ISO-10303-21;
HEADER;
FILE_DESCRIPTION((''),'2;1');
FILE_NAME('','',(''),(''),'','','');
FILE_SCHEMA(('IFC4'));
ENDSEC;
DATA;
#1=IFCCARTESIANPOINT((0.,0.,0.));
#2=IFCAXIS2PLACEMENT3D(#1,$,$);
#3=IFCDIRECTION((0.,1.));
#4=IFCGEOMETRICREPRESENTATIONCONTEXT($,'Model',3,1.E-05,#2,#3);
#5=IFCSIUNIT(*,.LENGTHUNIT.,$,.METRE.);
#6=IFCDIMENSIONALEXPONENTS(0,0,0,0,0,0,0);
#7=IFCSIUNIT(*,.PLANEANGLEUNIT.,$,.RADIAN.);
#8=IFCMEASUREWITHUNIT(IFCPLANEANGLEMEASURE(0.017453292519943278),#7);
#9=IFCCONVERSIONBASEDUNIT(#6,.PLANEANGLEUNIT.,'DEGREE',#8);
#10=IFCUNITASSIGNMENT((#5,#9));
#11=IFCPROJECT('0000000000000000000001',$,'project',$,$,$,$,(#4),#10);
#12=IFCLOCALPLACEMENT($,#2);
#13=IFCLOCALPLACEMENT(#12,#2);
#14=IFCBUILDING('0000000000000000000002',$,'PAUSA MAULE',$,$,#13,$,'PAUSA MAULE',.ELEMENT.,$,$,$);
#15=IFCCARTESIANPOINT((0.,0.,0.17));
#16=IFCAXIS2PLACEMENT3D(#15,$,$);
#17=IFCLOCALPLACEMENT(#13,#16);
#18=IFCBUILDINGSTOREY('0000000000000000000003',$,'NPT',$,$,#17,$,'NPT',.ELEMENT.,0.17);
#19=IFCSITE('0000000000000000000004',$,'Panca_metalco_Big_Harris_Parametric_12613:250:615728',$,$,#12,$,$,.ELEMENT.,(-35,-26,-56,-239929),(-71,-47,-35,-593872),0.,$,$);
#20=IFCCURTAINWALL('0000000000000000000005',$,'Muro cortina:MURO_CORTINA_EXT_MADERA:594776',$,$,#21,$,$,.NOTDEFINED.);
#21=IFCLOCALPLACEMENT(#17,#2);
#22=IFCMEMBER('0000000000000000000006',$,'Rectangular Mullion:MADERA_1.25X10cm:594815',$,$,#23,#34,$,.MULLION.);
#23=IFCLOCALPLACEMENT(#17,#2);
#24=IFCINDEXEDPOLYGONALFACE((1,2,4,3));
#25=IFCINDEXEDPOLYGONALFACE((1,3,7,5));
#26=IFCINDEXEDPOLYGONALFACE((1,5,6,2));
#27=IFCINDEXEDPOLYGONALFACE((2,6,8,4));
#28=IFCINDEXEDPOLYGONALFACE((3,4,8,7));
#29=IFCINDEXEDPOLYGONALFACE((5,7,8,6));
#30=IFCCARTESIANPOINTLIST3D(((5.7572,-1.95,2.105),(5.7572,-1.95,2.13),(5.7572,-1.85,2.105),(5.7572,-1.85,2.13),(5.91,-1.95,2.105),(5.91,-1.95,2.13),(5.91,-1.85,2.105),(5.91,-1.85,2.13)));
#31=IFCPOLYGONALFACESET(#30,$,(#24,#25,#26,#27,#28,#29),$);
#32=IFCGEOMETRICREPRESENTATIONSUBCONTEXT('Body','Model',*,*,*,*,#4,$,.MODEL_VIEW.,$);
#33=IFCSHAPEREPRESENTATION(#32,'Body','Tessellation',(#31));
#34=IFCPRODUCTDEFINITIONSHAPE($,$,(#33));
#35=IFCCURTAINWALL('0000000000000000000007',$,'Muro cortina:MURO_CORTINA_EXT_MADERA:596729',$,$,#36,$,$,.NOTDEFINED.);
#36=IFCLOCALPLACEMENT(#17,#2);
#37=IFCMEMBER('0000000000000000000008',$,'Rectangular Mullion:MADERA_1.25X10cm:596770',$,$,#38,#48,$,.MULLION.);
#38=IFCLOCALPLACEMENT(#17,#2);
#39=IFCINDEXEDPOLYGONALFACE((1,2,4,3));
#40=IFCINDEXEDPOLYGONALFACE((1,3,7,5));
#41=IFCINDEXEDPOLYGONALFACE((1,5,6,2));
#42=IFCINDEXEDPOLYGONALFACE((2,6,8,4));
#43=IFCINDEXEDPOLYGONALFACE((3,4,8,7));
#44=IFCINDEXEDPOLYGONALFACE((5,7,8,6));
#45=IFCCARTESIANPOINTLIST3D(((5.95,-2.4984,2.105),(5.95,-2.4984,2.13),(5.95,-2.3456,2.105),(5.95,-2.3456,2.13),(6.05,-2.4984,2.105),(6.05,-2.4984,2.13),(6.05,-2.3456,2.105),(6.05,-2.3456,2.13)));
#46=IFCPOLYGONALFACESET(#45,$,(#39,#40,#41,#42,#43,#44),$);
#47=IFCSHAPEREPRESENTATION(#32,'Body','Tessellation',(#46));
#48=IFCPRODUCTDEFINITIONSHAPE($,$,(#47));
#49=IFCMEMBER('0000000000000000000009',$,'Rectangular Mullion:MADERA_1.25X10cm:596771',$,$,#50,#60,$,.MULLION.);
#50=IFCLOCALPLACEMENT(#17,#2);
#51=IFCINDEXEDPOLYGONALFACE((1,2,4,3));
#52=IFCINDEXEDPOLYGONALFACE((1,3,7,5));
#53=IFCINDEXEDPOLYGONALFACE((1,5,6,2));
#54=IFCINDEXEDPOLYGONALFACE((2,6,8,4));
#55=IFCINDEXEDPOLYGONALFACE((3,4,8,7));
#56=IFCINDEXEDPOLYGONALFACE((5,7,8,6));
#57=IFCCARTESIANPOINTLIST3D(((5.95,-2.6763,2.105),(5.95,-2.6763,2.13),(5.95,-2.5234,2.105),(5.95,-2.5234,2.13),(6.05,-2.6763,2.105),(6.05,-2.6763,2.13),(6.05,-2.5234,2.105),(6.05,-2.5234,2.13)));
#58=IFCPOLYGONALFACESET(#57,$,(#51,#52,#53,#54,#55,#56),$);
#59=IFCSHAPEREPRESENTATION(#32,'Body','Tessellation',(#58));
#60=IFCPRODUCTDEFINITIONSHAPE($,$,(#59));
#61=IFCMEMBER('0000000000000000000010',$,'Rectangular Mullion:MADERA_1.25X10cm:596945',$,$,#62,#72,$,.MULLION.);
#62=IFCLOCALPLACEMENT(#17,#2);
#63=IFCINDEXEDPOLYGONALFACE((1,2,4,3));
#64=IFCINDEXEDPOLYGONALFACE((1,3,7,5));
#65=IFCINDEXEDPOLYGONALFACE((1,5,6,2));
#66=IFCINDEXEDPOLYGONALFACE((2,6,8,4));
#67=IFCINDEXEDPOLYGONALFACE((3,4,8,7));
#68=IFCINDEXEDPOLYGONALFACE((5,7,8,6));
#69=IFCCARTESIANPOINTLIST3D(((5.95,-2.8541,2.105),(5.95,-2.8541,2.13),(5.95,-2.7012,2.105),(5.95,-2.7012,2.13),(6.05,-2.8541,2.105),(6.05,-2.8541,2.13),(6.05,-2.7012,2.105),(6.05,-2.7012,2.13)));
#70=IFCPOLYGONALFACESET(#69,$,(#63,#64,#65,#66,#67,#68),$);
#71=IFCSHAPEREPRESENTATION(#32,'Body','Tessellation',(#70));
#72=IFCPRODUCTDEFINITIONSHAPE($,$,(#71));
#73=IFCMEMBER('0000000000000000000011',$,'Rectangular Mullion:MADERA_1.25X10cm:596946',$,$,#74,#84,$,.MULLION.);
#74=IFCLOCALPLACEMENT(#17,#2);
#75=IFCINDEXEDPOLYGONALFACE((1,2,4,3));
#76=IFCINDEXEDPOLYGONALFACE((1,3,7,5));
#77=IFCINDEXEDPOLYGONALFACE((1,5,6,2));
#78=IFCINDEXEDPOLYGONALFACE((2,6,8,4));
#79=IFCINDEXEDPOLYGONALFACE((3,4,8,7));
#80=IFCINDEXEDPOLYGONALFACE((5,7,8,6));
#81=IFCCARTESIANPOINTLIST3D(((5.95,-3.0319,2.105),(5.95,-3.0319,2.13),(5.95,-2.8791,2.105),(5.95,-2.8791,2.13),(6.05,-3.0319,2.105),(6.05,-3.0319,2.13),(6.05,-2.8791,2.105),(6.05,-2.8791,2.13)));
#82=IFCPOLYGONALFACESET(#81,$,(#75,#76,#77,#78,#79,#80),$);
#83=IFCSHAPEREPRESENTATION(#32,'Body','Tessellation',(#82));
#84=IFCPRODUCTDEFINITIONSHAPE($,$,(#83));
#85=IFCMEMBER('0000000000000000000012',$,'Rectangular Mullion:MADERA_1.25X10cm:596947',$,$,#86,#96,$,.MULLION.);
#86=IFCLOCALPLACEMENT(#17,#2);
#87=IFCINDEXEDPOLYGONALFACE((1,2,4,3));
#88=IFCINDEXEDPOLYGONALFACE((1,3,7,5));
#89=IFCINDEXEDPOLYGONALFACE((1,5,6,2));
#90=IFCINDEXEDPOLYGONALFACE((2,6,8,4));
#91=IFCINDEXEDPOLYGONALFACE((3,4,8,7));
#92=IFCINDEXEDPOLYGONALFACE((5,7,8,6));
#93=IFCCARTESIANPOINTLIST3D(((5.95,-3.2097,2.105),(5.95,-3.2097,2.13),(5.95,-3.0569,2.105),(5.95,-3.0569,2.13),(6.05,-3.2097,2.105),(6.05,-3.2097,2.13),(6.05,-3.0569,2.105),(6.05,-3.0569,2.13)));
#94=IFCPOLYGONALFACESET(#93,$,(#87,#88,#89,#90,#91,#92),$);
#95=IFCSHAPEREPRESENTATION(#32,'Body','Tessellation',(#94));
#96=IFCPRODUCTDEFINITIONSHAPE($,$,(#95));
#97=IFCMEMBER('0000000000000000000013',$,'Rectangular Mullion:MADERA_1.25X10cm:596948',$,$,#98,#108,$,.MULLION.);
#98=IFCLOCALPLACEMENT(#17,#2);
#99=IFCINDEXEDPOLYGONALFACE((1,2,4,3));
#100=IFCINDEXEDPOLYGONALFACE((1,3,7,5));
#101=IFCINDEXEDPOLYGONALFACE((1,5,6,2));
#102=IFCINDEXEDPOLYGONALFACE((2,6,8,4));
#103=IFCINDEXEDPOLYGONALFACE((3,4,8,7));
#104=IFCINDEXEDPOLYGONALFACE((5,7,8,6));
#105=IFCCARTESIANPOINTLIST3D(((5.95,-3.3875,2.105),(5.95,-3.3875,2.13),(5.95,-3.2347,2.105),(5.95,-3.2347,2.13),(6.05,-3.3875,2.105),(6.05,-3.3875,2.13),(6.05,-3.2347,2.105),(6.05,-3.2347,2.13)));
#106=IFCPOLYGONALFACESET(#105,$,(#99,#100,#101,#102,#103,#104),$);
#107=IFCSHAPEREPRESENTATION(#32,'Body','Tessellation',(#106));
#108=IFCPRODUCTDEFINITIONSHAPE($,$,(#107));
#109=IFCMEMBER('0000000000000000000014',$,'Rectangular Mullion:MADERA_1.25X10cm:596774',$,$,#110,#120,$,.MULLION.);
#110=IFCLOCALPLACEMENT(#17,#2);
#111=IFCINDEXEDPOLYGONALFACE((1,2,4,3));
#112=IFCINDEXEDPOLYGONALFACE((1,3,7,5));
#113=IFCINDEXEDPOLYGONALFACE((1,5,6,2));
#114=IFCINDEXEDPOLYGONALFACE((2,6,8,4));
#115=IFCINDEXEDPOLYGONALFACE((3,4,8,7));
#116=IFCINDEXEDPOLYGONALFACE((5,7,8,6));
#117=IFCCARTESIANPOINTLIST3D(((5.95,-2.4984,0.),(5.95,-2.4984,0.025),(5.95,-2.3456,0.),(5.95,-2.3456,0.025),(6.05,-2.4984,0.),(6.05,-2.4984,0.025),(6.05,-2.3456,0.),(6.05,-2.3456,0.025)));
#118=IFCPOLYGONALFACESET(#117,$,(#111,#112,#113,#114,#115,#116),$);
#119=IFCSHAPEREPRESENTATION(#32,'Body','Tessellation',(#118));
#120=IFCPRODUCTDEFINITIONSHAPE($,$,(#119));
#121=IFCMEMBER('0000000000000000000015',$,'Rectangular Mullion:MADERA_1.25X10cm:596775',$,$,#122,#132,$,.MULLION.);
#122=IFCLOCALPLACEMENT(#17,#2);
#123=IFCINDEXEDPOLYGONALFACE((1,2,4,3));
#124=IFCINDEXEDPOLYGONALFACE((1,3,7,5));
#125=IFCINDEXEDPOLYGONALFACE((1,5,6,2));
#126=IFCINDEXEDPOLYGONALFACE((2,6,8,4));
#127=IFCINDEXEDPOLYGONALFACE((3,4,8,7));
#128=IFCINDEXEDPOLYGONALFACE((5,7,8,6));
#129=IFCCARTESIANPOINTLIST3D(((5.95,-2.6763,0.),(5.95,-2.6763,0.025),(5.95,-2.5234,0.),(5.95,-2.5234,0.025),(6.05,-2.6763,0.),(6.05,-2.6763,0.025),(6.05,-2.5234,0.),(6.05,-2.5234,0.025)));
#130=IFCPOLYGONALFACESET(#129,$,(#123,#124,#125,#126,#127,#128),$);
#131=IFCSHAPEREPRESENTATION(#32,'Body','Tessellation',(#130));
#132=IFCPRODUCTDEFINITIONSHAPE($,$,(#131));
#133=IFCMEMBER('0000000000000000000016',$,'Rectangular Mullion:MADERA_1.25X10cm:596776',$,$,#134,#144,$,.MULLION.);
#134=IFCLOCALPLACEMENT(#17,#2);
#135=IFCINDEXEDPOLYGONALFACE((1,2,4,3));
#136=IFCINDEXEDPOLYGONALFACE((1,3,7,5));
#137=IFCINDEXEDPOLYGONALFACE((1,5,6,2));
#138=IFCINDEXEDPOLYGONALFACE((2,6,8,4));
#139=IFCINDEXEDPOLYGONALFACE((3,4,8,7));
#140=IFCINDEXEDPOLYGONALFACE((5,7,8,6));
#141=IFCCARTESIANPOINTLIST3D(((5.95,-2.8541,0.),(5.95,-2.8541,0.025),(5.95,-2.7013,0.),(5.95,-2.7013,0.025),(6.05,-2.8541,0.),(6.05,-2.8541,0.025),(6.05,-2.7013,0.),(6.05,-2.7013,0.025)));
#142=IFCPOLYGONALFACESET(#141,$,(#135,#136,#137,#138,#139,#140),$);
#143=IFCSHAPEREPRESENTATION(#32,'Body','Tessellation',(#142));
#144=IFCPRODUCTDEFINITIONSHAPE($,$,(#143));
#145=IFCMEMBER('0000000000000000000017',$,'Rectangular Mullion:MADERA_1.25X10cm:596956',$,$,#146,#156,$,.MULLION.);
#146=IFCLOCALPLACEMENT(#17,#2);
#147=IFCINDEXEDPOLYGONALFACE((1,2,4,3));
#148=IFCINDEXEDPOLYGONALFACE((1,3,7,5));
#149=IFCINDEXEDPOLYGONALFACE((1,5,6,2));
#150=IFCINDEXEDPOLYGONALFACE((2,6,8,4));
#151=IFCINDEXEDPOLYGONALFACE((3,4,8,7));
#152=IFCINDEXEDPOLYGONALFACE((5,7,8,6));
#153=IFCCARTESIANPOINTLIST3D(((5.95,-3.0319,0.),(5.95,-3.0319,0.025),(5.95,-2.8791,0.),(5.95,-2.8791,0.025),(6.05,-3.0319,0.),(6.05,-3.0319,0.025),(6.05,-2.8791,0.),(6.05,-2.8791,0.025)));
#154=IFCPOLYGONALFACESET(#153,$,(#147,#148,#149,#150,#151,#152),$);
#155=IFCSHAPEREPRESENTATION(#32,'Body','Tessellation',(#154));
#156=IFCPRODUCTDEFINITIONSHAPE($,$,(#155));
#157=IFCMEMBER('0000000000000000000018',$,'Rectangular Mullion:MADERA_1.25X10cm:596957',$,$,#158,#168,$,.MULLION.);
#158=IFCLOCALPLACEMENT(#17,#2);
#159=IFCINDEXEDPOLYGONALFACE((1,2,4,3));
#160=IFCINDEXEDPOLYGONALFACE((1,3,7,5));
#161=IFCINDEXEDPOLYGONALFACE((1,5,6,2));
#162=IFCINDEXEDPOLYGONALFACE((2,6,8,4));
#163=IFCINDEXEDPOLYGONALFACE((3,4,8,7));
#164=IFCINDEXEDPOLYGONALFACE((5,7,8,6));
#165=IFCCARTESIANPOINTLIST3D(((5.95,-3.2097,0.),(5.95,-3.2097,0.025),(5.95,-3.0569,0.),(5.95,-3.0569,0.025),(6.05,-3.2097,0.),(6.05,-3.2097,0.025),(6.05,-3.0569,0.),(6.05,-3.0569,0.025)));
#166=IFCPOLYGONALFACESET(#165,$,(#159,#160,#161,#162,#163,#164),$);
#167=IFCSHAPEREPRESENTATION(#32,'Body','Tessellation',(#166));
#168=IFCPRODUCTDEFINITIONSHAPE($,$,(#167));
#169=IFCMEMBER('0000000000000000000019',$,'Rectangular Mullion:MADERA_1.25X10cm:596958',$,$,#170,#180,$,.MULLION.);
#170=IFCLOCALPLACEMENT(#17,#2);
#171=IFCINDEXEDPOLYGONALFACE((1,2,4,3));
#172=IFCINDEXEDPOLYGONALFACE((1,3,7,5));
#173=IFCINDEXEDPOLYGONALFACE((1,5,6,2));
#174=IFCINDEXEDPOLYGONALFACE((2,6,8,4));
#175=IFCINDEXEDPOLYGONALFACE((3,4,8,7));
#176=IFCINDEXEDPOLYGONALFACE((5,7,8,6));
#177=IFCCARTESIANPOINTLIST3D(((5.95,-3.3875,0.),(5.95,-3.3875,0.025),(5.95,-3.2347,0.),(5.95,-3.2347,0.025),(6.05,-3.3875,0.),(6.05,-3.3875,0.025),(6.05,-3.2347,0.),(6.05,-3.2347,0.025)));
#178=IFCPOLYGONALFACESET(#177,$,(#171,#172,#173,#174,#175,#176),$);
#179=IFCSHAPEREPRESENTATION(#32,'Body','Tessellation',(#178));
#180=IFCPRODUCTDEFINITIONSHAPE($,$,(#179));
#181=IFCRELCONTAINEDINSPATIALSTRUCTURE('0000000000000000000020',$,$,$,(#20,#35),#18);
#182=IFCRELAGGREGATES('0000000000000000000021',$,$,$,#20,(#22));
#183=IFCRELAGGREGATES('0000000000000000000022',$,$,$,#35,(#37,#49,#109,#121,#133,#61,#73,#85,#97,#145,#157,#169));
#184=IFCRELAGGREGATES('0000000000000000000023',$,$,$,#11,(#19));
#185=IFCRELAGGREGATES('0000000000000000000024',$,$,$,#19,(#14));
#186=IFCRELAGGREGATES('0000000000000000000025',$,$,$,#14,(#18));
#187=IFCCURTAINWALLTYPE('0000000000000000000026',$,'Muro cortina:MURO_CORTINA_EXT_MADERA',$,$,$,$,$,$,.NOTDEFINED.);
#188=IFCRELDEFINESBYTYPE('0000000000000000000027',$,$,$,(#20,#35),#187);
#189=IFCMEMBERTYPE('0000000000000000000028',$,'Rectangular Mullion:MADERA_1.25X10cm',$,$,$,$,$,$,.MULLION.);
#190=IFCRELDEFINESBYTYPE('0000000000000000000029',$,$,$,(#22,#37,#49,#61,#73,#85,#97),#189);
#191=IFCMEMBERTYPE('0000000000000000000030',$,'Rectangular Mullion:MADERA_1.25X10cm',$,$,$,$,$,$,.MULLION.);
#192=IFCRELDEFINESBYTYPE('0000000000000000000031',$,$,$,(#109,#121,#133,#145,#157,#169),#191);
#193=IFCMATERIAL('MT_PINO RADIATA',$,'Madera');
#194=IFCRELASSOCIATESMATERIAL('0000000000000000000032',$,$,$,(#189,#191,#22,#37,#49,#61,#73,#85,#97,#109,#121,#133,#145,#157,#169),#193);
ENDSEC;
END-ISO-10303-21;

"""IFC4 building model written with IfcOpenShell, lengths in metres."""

from ifc_helpers import new_model, entity, si_unit, converted_unit, direction, frame, frame_2d, origin, place, context, subcontext, project, spatial, rectangle, extrude, source, transform, mapped, material, material_profile, profile_set, profile_usage, type_object, type_shapes, element, aggregate, save


model = new_model("IFC4")

# Units and contexts
model_context = context("Model", 3, precision=1e-05, world=origin(), true_north=direction((0.0, 1.0)))
body_context = subcontext(model_context, "Body", "Model", "MODEL_VIEW")
ifc_project = project(units=[si_unit("LENGTHUNIT", "METRE"), converted_unit("PLANEANGLEUNIT", "DEGREE", entity("IfcPlaneAngleMeasure", 0.017453292519943278), si_unit("PLANEANGLEUNIT", "RADIAN"), dimensions=[0, 0, 0, 0, 0, 0, 0])], contexts=[model_context])

# Site, building, storey
site_placement = place(None, origin())
site = spatial("IfcSite", under=ifc_project, at=site_placement, Name="Panca_metalco_Big_Harris_Parametric_12613:250:615728", CompositionType="ELEMENT", RefLatitude=(-35, -26, -56, -239929), RefLongitude=(-71, -47, -35, -593872), RefElevation=0.0)
building_placement = place(site_placement, origin())
building = spatial("IfcBuilding", under=site, at=building_placement, Name="PAUSA MAULE", LongName="PAUSA MAULE", CompositionType="ELEMENT")
storey_placement = place(building_placement, frame((0.0, 0.0, 0.17)))
storey = spatial("IfcBuildingStorey", under=building, at=storey_placement, Name="NPT", LongName="NPT", CompositionType="ELEMENT", Elevation=0.17)

# Curtain wall, member
curtain_wall_type = type_object("IfcCurtainWallType", Name="Muro cortina:MURO_CORTINA_EXT_MADERA", PredefinedType="NOTDEFINED")
curtain_wall_1_placement = place(storey_placement, frame((0.0, 0.0, -0.17)))
curtain_wall_1 = element("IfcCurtainWall", 1, at=curtain_wall_1_placement, inside=storey, type_object=curtain_wall_type, Name="Muro cortina:MURO_CORTINA_EXT_MADERA:594776", PredefinedType="NOTDEFINED")
ifc_material = material(Name="MT_PINO RADIATA", Category="Madera")
ifc_material_profile = material_profile(ifc_material, rectangle(XDim=0.025, YDim=0.1, at=frame_2d((0.0, 0.0), x_axis=(1.0, 0.0))), Name="MADERA_1.25X10cm")
ifc_profile_set = profile_set([ifc_material_profile], Name="MADERA_1.25X10cm")
ifc_profile_usage = profile_usage(ifc_profile_set)
member_type_1 = type_object("IfcMemberType", Name="Rectangular Mullion:MADERA_1.25X10cm", PredefinedType="MULLION", material=ifc_profile_set)
shared_shape_1 = source(origin(), body_context, "Body", "SweptSolid", [
    extrude(rectangle(XDim=0.025, YDim=0.1, at=frame_2d((0.0, 0.0), x_axis=(1.0, 0.0))), frame((-0.0125, 0.0, -0.1528), z_axis=(0.0, 0.0, 1.0), x_axis=(-1.0, 0.0, 0.0)), (0.0, 0.0, 1.0), 0.1528),
])
type_shapes(member_type_1, [shared_shape_1])
member_1_placement = place(curtain_wall_1_placement, frame((5.91, -1.9, 2.3), z_axis=(1.0, 0.0, 0.0), x_axis=(0.0, 0.0, 1.0)))
member_1 = element("IfcMember", 2, at=member_1_placement, type_object=member_type_1, material=ifc_profile_usage, Name="Rectangular Mullion:MADERA_1.25X10cm:594815", PredefinedType="MULLION", context=body_context, shape_type="MappedRepresentation", body=[
    mapped(shared_shape_1, transform((0.0, 0.0, 0.0), scale=1.0)),
])

# Curtain wall, members
curtain_wall_2_placement = place(storey_placement, frame((0.0, 0.0, -0.17)))
curtain_wall_2 = element("IfcCurtainWall", 3, at=curtain_wall_2_placement, inside=storey, type_object=curtain_wall_type, Name="Muro cortina:MURO_CORTINA_EXT_MADERA:596729", PredefinedType="NOTDEFINED")
member_2_placement = place(curtain_wall_2_placement, frame((6.0, -2.4984, 2.3), z_axis=(0.0, -1.0, 0.0), x_axis=(0.0, 0.0, 1.0)))
member_2 = element("IfcMember", 4, at=member_2_placement, type_object=member_type_1, material=ifc_profile_usage, Name="Rectangular Mullion:MADERA_1.25X10cm:596770", PredefinedType="MULLION", context=body_context, shape_type="MappedRepresentation", body=[
    mapped(shared_shape_1, transform((0.0, 0.0, 0.0), scale=1.0)),
])
member_3_placement = place(curtain_wall_2_placement, frame((6.0, -2.6763, 2.3), z_axis=(0.0, -1.0, 0.0), x_axis=(0.0, 0.0, 1.0)))
member_3 = element("IfcMember", 5, at=member_3_placement, type_object=member_type_1, material=ifc_profile_usage, Name="Rectangular Mullion:MADERA_1.25X10cm:596771", PredefinedType="MULLION", context=body_context, shape_type="MappedRepresentation", body=[
    mapped(shared_shape_1, transform((0.0, 0.0, 0.0), scale=1.0)),
])
member_4_placement = place(curtain_wall_2_placement, frame((6.0, -2.8541, 2.3), z_axis=(0.0, -1.0, 0.0), x_axis=(0.0, 0.0, 1.0)))
member_4 = element("IfcMember", 6, at=member_4_placement, type_object=member_type_1, material=ifc_profile_usage, Name="Rectangular Mullion:MADERA_1.25X10cm:596945", PredefinedType="MULLION", context=body_context, shape_type="MappedRepresentation", body=[
    mapped(shared_shape_1, transform((0.0, 0.0, 0.0), scale=1.0)),
])
member_5_placement = place(curtain_wall_2_placement, frame((6.0, -3.0319, 2.3), z_axis=(0.0, -1.0, 0.0), x_axis=(0.0, 0.0, 1.0)))
member_5 = element("IfcMember", 7, at=member_5_placement, type_object=member_type_1, material=ifc_profile_usage, Name="Rectangular Mullion:MADERA_1.25X10cm:596946", PredefinedType="MULLION", context=body_context, shape_type="MappedRepresentation", body=[
    mapped(shared_shape_1, transform((0.0, 0.0, 0.0), scale=1.0)),
])
member_6_placement = place(curtain_wall_2_placement, frame((6.0, -3.2097, 2.3), z_axis=(0.0, -1.0, 0.0), x_axis=(0.0, 0.0, 1.0)))
member_6 = element("IfcMember", 8, at=member_6_placement, type_object=member_type_1, material=ifc_profile_usage, Name="Rectangular Mullion:MADERA_1.25X10cm:596947", PredefinedType="MULLION", context=body_context, shape_type="MappedRepresentation", body=[
    mapped(shared_shape_1, transform((0.0, 0.0, 0.0), scale=1.0)),
])
member_7_placement = place(curtain_wall_2_placement, frame((6.0, -3.3875, 2.3), z_axis=(0.0, -1.0, 0.0), x_axis=(0.0, 0.0, 1.0)))
member_7 = element("IfcMember", 9, at=member_7_placement, type_object=member_type_1, material=ifc_profile_usage, Name="Rectangular Mullion:MADERA_1.25X10cm:596948", PredefinedType="MULLION", context=body_context, shape_type="MappedRepresentation", body=[
    mapped(shared_shape_1, transform((0.0, 0.0, 0.0), scale=1.0)),
])
member_type_2 = type_object("IfcMemberType", Name="Rectangular Mullion:MADERA_1.25X10cm", PredefinedType="MULLION", material=ifc_profile_set)
shared_shape_2 = source(origin(), body_context, "Body", "SweptSolid", [
    extrude(rectangle(XDim=0.025, YDim=0.1, at=frame_2d((0.0, 0.0), x_axis=(1.0, 0.0))), frame((-0.0125, 0.0, -0.1528), z_axis=(0.0, 0.0, 1.0), x_axis=(-1.0, 0.0, 0.0)), (0.0, 0.0, 1.0), 0.1528),
])
type_shapes(member_type_2, [shared_shape_2])
member_8_placement = place(curtain_wall_2_placement, frame((6.0, -2.3456, 0.17), z_axis=(0.0, 1.0, 0.0), x_axis=(0.0, 0.0, -1.0)))
member_8 = element("IfcMember", 10, at=member_8_placement, type_object=member_type_2, material=ifc_profile_usage, Name="Rectangular Mullion:MADERA_1.25X10cm:596774", PredefinedType="MULLION", context=body_context, shape_type="MappedRepresentation", body=[
    mapped(shared_shape_2, transform((0.0, 0.0, 0.0), scale=1.0)),
])
member_9_placement = place(curtain_wall_2_placement, frame((6.0, -2.5234, 0.17), z_axis=(0.0, 1.0, 0.0), x_axis=(0.0, 0.0, -1.0)))
member_9 = element("IfcMember", 11, at=member_9_placement, type_object=member_type_2, material=ifc_profile_usage, Name="Rectangular Mullion:MADERA_1.25X10cm:596775", PredefinedType="MULLION", context=body_context, shape_type="MappedRepresentation", body=[
    mapped(shared_shape_2, transform((0.0, 0.0, 0.0), scale=1.0)),
])
member_10_placement = place(curtain_wall_2_placement, frame((6.0, -2.7013, 0.17), z_axis=(0.0, 1.0, 0.0), x_axis=(0.0, 0.0, -1.0)))
member_10 = element("IfcMember", 12, at=member_10_placement, type_object=member_type_2, material=ifc_profile_usage, Name="Rectangular Mullion:MADERA_1.25X10cm:596776", PredefinedType="MULLION", context=body_context, shape_type="MappedRepresentation", body=[
    mapped(shared_shape_2, transform((0.0, 0.0, 0.0), scale=1.0)),
])
member_11_placement = place(curtain_wall_2_placement, frame((6.0, -2.8791, 0.17), z_axis=(0.0, 1.0, 0.0), x_axis=(0.0, 0.0, -1.0)))
member_11 = element("IfcMember", 13, at=member_11_placement, type_object=member_type_2, material=ifc_profile_usage, Name="Rectangular Mullion:MADERA_1.25X10cm:596956", PredefinedType="MULLION", context=body_context, shape_type="MappedRepresentation", body=[
    mapped(shared_shape_2, transform((0.0, 0.0, 0.0), scale=1.0)),
])
member_12_placement = place(curtain_wall_2_placement, frame((6.0, -3.0569, 0.17), z_axis=(0.0, 1.0, 0.0), x_axis=(0.0, 0.0, -1.0)))
member_12 = element("IfcMember", 14, at=member_12_placement, type_object=member_type_2, material=ifc_profile_usage, Name="Rectangular Mullion:MADERA_1.25X10cm:596957", PredefinedType="MULLION", context=body_context, shape_type="MappedRepresentation", body=[
    mapped(shared_shape_2, transform((0.0, 0.0, 0.0), scale=1.0)),
])
member_13_placement = place(curtain_wall_2_placement, frame((6.0, -3.2347, 0.17), z_axis=(0.0, 1.0, 0.0), x_axis=(0.0, 0.0, -1.0)))
member_13 = element("IfcMember", 15, at=member_13_placement, type_object=member_type_2, material=ifc_profile_usage, Name="Rectangular Mullion:MADERA_1.25X10cm:596958", PredefinedType="MULLION", context=body_context, shape_type="MappedRepresentation", body=[
    mapped(shared_shape_2, transform((0.0, 0.0, 0.0), scale=1.0)),
])

aggregate(curtain_wall_1, [member_1])
aggregate(curtain_wall_2, [member_2, member_3, member_8, member_9, member_10, member_4, member_5, member_6, member_7, member_11, member_12, member_13])

save(model, "model.ifc")
